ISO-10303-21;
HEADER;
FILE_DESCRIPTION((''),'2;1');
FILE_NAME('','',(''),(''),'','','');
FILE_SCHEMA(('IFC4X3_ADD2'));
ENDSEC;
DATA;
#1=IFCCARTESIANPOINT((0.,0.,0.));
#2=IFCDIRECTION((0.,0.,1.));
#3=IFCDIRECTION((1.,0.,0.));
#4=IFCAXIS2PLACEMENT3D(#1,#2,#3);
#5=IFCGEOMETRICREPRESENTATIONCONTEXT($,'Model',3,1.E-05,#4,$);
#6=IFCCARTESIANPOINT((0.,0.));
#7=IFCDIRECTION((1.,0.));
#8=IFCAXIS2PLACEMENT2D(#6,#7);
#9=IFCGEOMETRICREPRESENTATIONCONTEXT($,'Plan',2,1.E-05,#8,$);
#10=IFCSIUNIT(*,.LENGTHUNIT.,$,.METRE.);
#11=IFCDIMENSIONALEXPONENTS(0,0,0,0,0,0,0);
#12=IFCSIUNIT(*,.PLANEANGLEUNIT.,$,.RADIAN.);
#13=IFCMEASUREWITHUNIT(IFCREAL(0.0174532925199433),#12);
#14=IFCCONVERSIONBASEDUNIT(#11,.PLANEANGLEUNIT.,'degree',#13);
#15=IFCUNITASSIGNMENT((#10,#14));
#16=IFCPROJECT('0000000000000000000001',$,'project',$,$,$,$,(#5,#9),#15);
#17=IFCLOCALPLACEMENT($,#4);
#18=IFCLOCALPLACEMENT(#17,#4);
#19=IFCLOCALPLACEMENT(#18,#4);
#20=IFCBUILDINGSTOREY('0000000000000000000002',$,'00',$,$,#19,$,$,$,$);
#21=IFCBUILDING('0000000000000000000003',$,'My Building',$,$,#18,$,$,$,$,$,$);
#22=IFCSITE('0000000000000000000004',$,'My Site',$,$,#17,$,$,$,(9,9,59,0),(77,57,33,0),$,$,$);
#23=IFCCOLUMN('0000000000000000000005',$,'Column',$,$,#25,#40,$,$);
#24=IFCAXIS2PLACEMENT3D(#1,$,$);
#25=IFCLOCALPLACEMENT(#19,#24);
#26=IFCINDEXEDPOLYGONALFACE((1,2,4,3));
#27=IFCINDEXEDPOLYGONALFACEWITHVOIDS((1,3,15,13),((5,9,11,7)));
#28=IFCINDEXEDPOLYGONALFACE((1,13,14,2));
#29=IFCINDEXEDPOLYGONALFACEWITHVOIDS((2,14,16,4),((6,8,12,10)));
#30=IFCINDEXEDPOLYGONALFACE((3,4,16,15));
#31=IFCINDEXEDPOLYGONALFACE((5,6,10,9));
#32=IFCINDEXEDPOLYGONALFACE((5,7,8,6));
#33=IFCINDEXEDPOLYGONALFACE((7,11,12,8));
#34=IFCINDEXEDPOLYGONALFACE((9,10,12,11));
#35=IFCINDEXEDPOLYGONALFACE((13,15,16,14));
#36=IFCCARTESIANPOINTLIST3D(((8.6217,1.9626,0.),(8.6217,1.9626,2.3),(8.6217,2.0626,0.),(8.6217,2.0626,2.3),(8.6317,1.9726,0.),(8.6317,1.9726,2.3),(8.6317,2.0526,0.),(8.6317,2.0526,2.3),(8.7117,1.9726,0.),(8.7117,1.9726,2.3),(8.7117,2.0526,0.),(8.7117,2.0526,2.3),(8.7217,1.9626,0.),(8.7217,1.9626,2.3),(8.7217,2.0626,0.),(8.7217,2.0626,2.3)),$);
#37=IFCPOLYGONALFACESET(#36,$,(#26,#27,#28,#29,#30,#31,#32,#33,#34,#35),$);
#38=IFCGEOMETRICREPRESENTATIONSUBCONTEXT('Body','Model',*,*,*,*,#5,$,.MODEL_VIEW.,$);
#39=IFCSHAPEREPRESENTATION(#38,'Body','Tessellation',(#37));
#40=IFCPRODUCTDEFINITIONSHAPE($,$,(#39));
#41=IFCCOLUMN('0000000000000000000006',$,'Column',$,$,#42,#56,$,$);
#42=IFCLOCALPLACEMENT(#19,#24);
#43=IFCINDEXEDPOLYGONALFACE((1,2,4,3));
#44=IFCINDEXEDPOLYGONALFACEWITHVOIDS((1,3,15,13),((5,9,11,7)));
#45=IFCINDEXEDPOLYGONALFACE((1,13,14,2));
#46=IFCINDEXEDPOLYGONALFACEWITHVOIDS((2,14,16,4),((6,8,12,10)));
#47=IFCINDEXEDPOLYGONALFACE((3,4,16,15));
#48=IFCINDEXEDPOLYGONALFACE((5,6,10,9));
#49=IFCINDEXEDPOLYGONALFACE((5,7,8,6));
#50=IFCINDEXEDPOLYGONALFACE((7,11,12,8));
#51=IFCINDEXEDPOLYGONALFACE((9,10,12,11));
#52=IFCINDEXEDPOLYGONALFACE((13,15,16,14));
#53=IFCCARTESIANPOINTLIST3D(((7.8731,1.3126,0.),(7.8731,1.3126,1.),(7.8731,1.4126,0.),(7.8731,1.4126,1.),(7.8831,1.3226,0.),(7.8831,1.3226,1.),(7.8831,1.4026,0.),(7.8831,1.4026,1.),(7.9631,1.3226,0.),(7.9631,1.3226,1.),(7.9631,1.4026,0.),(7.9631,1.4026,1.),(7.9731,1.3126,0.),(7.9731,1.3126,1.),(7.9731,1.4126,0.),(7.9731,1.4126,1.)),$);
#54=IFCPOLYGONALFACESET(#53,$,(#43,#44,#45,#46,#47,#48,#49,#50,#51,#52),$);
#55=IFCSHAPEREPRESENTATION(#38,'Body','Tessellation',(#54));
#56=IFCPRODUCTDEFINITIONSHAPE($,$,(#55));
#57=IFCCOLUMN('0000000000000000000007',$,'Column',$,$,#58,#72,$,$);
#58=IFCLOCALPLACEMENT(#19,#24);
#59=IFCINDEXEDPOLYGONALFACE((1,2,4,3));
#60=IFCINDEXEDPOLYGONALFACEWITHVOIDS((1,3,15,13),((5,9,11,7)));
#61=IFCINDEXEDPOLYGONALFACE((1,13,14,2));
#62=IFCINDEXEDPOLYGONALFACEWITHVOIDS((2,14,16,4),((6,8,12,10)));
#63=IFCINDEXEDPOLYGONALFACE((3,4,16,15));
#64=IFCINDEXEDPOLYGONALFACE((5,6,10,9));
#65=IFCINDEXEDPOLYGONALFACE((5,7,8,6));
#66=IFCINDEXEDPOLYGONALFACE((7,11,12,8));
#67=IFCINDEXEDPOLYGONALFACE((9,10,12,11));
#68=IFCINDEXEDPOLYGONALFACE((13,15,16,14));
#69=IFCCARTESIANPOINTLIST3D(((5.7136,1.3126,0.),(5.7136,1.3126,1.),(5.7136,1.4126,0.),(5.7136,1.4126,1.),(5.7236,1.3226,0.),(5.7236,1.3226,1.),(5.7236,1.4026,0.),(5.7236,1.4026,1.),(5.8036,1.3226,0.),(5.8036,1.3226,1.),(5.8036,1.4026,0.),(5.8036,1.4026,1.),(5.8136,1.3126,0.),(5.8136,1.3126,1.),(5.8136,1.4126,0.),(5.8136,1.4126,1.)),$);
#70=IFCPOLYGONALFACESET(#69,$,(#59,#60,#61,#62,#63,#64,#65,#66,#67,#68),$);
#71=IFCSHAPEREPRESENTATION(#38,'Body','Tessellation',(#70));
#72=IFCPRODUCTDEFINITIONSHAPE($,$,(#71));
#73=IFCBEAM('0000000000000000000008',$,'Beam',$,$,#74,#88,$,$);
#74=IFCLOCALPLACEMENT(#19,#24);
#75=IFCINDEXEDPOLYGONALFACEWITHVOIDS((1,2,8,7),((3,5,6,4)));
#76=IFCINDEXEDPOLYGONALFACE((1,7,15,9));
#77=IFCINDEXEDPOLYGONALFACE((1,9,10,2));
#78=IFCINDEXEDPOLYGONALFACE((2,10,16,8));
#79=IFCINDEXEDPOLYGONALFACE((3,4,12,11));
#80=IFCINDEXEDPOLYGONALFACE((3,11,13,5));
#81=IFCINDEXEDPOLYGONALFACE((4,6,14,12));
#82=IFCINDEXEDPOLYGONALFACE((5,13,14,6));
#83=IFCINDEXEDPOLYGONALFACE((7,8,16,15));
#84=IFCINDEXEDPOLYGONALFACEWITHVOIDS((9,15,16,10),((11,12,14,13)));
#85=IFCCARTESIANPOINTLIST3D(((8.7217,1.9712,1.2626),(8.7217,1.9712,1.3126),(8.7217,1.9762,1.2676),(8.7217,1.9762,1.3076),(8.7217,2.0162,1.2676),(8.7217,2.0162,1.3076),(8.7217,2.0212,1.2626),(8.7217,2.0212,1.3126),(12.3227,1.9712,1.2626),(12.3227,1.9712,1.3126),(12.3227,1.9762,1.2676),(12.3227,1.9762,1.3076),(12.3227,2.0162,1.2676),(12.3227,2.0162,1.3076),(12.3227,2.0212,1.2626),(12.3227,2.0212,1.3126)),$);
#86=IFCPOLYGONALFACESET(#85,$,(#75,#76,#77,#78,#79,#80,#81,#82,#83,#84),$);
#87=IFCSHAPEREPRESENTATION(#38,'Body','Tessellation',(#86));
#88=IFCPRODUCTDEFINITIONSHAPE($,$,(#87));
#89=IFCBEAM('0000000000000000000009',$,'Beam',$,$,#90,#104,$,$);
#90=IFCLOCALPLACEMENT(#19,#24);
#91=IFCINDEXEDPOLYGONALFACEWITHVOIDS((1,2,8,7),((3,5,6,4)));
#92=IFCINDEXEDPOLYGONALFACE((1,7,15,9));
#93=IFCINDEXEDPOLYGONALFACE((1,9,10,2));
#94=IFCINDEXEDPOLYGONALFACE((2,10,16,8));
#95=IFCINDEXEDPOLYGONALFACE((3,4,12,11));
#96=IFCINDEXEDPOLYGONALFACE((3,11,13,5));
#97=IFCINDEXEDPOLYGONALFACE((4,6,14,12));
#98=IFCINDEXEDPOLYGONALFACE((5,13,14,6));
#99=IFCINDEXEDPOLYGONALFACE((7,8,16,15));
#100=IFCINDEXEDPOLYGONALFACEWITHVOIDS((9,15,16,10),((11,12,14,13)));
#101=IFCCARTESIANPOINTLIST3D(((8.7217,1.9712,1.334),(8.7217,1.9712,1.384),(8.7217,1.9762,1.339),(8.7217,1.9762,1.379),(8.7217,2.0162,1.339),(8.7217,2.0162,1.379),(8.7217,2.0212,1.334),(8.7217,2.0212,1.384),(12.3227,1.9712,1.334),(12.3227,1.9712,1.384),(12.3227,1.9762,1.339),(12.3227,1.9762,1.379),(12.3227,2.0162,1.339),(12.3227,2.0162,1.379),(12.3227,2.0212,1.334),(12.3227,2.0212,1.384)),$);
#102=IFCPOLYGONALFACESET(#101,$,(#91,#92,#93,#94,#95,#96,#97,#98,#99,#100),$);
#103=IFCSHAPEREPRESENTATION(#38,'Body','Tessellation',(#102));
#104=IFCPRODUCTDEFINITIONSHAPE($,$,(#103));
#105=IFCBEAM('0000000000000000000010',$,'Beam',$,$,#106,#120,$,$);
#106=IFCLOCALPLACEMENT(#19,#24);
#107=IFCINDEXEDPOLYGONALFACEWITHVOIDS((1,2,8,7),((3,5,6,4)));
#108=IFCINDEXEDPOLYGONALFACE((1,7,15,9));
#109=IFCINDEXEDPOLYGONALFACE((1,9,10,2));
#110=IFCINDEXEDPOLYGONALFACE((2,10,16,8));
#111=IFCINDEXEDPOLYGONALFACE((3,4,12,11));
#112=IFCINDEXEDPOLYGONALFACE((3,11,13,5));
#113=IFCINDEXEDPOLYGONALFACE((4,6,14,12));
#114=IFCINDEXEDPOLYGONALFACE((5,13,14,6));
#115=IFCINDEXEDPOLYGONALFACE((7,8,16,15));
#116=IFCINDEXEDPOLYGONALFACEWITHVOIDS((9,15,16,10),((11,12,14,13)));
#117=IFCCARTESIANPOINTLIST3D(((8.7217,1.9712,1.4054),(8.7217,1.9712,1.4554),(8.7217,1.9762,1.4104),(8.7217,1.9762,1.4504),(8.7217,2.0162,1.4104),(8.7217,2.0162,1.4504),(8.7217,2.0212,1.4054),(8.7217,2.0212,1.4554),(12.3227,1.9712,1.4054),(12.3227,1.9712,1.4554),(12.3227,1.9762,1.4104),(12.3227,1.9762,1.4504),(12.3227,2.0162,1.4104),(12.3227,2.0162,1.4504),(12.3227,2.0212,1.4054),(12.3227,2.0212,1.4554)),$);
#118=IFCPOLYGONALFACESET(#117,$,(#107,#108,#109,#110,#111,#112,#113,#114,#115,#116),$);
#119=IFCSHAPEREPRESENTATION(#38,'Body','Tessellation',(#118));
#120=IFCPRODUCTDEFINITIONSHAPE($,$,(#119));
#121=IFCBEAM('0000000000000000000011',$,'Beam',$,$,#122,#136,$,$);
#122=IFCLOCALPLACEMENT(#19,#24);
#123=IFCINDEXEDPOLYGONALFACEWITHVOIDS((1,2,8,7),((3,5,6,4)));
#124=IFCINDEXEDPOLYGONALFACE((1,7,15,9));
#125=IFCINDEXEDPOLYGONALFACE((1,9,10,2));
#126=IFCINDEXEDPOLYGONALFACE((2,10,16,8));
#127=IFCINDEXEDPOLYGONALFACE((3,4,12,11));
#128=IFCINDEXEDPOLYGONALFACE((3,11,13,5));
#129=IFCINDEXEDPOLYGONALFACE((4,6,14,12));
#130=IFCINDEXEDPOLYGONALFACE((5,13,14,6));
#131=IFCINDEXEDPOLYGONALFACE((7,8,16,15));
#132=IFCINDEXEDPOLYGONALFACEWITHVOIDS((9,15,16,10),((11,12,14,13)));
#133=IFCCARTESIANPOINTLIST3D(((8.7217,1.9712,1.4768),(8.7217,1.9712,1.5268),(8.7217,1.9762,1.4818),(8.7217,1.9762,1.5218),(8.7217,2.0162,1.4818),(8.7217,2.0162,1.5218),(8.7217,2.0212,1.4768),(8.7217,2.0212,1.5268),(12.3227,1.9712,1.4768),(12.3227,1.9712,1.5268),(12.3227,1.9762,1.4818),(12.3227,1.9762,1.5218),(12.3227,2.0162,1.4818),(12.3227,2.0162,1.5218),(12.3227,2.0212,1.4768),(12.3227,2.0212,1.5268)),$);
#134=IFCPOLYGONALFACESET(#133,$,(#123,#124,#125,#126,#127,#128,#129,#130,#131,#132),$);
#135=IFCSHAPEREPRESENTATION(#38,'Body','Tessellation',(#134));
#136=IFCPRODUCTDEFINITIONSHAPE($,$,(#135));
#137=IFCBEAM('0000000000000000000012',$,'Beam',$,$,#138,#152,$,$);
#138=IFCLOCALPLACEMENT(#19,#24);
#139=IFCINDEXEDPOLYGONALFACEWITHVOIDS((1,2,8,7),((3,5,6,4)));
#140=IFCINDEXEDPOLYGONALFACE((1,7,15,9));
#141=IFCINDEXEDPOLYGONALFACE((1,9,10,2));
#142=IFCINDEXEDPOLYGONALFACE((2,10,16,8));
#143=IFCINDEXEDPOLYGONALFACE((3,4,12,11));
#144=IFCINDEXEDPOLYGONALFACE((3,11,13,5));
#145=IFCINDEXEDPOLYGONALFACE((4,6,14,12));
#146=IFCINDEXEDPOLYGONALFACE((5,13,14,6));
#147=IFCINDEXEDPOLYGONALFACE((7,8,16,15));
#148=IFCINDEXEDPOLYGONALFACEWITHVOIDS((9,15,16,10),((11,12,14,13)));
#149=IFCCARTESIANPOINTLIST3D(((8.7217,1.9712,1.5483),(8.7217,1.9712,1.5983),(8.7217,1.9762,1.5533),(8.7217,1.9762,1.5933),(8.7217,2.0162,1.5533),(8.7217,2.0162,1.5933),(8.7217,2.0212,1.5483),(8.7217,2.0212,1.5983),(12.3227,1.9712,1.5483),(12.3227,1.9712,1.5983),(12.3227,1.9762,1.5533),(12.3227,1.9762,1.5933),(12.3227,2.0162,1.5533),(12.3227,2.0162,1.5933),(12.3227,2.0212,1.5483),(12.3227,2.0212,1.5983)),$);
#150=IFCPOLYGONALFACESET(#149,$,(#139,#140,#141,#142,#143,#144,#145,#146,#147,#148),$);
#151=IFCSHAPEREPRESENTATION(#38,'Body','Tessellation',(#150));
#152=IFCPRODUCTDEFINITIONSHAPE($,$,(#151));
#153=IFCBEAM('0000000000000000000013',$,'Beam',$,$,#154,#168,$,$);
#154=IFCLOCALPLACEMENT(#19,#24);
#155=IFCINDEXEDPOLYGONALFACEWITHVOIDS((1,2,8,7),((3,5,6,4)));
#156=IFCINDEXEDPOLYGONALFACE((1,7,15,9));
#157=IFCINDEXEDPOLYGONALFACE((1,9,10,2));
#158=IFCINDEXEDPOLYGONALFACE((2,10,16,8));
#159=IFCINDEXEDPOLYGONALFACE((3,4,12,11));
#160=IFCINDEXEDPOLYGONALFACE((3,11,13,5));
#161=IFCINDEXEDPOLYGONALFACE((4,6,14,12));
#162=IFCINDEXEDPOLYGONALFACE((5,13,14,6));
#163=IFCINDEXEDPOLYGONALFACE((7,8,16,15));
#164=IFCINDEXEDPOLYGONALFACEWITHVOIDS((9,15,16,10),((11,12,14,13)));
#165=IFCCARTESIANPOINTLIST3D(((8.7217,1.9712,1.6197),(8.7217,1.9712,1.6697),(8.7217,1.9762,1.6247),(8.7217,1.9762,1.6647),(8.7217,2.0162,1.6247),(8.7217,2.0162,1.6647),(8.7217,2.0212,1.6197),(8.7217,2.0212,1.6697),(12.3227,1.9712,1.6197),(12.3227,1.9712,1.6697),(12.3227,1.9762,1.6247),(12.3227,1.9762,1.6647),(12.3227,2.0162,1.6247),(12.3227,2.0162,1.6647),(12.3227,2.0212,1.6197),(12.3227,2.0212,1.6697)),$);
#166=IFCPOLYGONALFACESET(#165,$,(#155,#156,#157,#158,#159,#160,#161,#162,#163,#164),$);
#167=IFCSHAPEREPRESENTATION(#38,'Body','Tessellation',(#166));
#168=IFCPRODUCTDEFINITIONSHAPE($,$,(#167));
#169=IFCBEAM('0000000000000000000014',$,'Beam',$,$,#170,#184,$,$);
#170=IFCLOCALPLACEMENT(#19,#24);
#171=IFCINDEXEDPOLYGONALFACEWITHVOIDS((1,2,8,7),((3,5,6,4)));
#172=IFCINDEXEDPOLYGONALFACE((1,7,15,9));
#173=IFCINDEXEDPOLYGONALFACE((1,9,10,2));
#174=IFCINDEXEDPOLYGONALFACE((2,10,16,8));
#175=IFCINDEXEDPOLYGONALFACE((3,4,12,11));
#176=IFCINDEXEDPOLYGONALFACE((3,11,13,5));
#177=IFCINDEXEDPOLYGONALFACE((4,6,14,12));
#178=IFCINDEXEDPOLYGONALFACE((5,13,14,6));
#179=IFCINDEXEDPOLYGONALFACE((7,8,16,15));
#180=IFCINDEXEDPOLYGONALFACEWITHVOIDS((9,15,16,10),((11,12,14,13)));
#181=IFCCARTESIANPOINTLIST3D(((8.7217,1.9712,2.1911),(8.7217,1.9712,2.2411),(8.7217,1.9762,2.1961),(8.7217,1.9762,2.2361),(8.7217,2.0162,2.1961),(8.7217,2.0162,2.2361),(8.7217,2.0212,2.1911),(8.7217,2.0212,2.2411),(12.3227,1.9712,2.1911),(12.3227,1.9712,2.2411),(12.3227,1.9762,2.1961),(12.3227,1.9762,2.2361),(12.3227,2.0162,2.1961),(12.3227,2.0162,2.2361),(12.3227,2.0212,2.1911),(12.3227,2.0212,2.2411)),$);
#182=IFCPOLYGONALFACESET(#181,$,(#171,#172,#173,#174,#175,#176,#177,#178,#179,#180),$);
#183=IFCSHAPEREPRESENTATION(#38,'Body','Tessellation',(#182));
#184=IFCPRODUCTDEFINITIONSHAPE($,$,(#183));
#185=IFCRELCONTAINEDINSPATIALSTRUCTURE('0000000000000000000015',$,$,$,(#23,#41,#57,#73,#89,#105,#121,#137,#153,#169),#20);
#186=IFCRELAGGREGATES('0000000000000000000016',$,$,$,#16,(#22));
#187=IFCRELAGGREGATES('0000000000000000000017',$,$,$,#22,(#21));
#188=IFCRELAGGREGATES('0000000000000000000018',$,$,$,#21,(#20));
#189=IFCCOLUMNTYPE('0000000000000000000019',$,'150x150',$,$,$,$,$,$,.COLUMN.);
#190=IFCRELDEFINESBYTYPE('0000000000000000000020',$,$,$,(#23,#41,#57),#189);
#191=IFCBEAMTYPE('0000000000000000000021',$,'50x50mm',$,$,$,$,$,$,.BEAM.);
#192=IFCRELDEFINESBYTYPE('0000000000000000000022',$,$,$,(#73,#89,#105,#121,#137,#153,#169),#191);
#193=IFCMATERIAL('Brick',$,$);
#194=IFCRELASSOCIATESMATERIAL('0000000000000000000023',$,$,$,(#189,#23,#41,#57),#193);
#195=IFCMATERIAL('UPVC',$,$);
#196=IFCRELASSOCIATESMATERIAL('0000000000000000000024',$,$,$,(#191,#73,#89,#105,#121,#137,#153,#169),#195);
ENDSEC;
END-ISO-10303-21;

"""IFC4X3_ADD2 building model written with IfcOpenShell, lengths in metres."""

from ifc_helpers import new_model, entity, si_unit, converted_unit, frame, origin_with_axes, origin_2d_with_axis, place, context, subcontext, project, spatial, hollow_rectangle, extrude, material, material_profile, profile_set, profile_usage, type_object, element, save


model = new_model("IFC4X3_ADD2")

# Units and contexts
model_context = context("Model", 3, precision=1e-05, world=origin_with_axes())
plan_context = context("Plan", 2, precision=1e-05, world=origin_2d_with_axis())
body_context = subcontext(model_context, "Body", "Model", "MODEL_VIEW")
ifc_project = project(units=[si_unit("LENGTHUNIT", "METRE"), converted_unit("PLANEANGLEUNIT", "degree", entity("IfcReal", 0.0174532925199433), si_unit("PLANEANGLEUNIT", "RADIAN"), dimensions=[0, 0, 0, 0, 0, 0, 0])], contexts=[model_context, plan_context])

# Site, building, storey
site_placement = place(None, origin_with_axes())
site = spatial("IfcSite", under=ifc_project, at=site_placement, Name="My Site", RefLatitude=(9, 9, 59, 0), RefLongitude=(77, 57, 33, 0))
building_placement = place(site_placement, origin_with_axes())
building = spatial("IfcBuilding", under=site, at=building_placement, Name="My Building")
storey_placement = place(building_placement, origin_with_axes())
storey = spatial("IfcBuildingStorey", under=building, at=storey_placement, Name="00")

# Columns
ifc_material_1 = material(Name="Brick")
ifc_material_profile_1 = material_profile(ifc_material_1, hollow_rectangle(XDim=0.1, YDim=0.1, WallThickness=0.01))
ifc_profile_set_1 = profile_set([ifc_material_profile_1])
ifc_profile_usage_1 = profile_usage(ifc_profile_set_1, cardinal=5)
column_type = type_object("IfcColumnType", Name="150x150", PredefinedType="COLUMN", material=ifc_profile_set_1)
column_1_placement = place(storey_placement, frame((8.6717, 2.0126, 0.0), z_axis=(0.0, 0.0, 1.0), x_axis=(1.0, 0.0, 0.0)))
element("IfcColumn", 1, at=column_1_placement, inside=storey, type_object=column_type, material=ifc_profile_usage_1, Name="Column", context=body_context, shape_type="SweptSolid", body=[
    extrude(hollow_rectangle(XDim=0.1, YDim=0.1, WallThickness=0.01), origin_with_axes(), (0.0, 0.0, 1.0), 2.3),
])
ifc_profile_usage_2 = profile_usage(ifc_profile_set_1, cardinal=5)
column_2_placement = place(storey_placement, frame((7.9231, 1.3626, 0.0), z_axis=(0.0, 0.0, 1.0), x_axis=(1.0, 0.0, 0.0)))
element("IfcColumn", 2, at=column_2_placement, inside=storey, type_object=column_type, material=ifc_profile_usage_2, Name="Column", context=body_context, shape_type="SweptSolid", body=[
    extrude(hollow_rectangle(XDim=0.1, YDim=0.1, WallThickness=0.01), origin_with_axes(), (0.0, 0.0, 1.0), 1.0),
])
ifc_profile_usage_3 = profile_usage(ifc_profile_set_1, cardinal=5)
column_3_placement = place(storey_placement, frame((5.7636, 1.3626, 0.0), z_axis=(0.0, 0.0, 1.0), x_axis=(1.0, 0.0, 0.0)))
element("IfcColumn", 3, at=column_3_placement, inside=storey, type_object=column_type, material=ifc_profile_usage_3, Name="Column", context=body_context, shape_type="SweptSolid", body=[
    extrude(hollow_rectangle(XDim=0.1, YDim=0.1, WallThickness=0.01), origin_with_axes(), (0.0, 0.0, 1.0), 1.0),
])

# Beams
ifc_material_2 = material(Name="UPVC")
ifc_material_profile_2 = material_profile(ifc_material_2, hollow_rectangle(XDim=0.05, YDim=0.05, WallThickness=0.005))
ifc_profile_set_2 = profile_set([ifc_material_profile_2])
ifc_profile_usage_4 = profile_usage(ifc_profile_set_2, cardinal=5)
beam_type = type_object("IfcBeamType", Name="50x50mm", PredefinedType="BEAM", material=ifc_profile_set_2)
beam_1_placement = place(storey_placement, frame((8.7217, 1.9962, 1.2876), z_axis=(1.0, 0.0, 0.000001), x_axis=(0.0, 1.0, 0.0)))
element("IfcBeam", 4, at=beam_1_placement, inside=storey, type_object=beam_type, material=ifc_profile_usage_4, Name="Beam", context=body_context, shape_type="SweptSolid", body=[
    extrude(hollow_rectangle(XDim=0.05, YDim=0.05, WallThickness=0.005), origin_with_axes(), (0.0, 0.0, 1.0), 3.601),
])
ifc_profile_usage_5 = profile_usage(ifc_profile_set_2, cardinal=5)
beam_2_placement = place(storey_placement, frame((8.7217, 1.9962, 1.359), z_axis=(1.0, 0.0, 0.000001), x_axis=(0.0, 1.0, 0.0)))
element("IfcBeam", 5, at=beam_2_placement, inside=storey, type_object=beam_type, material=ifc_profile_usage_5, Name="Beam", context=body_context, shape_type="SweptSolid", body=[
    extrude(hollow_rectangle(XDim=0.05, YDim=0.05, WallThickness=0.005), origin_with_axes(), (0.0, 0.0, 1.0), 3.601),
])
ifc_profile_usage_6 = profile_usage(ifc_profile_set_2, cardinal=5)
beam_3_placement = place(storey_placement, frame((8.7217, 1.9962, 1.4304), z_axis=(1.0, 0.0, 0.000001), x_axis=(0.0, 1.0, 0.0)))
element("IfcBeam", 6, at=beam_3_placement, inside=storey, type_object=beam_type, material=ifc_profile_usage_6, Name="Beam", context=body_context, shape_type="SweptSolid", body=[
    extrude(hollow_rectangle(XDim=0.05, YDim=0.05, WallThickness=0.005), origin_with_axes(), (0.0, 0.0, 1.0), 3.601),
])
ifc_profile_usage_7 = profile_usage(ifc_profile_set_2, cardinal=5)
beam_4_placement = place(storey_placement, frame((8.7217, 1.9962, 1.5018), z_axis=(1.0, 0.0, 0.000001), x_axis=(0.0, 1.0, 0.0)))
element("IfcBeam", 7, at=beam_4_placement, inside=storey, type_object=beam_type, material=ifc_profile_usage_7, Name="Beam", context=body_context, shape_type="SweptSolid", body=[
    extrude(hollow_rectangle(XDim=0.05, YDim=0.05, WallThickness=0.005), origin_with_axes(), (0.0, 0.0, 1.0), 3.601),
])
ifc_profile_usage_8 = profile_usage(ifc_profile_set_2, cardinal=5)
beam_5_placement = place(storey_placement, frame((8.7217, 1.9962, 1.5733), z_axis=(1.0, 0.0, 0.000001), x_axis=(0.0, 1.0, 0.0)))
element("IfcBeam", 8, at=beam_5_placement, inside=storey, type_object=beam_type, material=ifc_profile_usage_8, Name="Beam", context=body_context, shape_type="SweptSolid", body=[
    extrude(hollow_rectangle(XDim=0.05, YDim=0.05, WallThickness=0.005), origin_with_axes(), (0.0, 0.0, 1.0), 3.601),
])
ifc_profile_usage_9 = profile_usage(ifc_profile_set_2, cardinal=5)
beam_6_placement = place(storey_placement, frame((8.7217, 1.9962, 1.6447), z_axis=(1.0, 0.0, 0.000001), x_axis=(0.0, 1.0, 0.0)))
element("IfcBeam", 9, at=beam_6_placement, inside=storey, type_object=beam_type, material=ifc_profile_usage_9, Name="Beam", context=body_context, shape_type="SweptSolid", body=[
    extrude(hollow_rectangle(XDim=0.05, YDim=0.05, WallThickness=0.005), origin_with_axes(), (0.0, 0.0, 1.0), 3.601),
])
ifc_profile_usage_10 = profile_usage(ifc_profile_set_2, cardinal=5)
beam_7_placement = place(storey_placement, frame((8.7217, 1.9962, 2.2161), z_axis=(1.0, 0.0, 0.000001), x_axis=(0.0, 1.0, 0.0)))
element("IfcBeam", 10, at=beam_7_placement, inside=storey, type_object=beam_type, material=ifc_profile_usage_10, Name="Beam", context=body_context, shape_type="SweptSolid", body=[
    extrude(hollow_rectangle(XDim=0.05, YDim=0.05, WallThickness=0.005), origin_with_axes(), (0.0, 0.0, 1.0), 3.601),
])

save(model, "model.ifc")
